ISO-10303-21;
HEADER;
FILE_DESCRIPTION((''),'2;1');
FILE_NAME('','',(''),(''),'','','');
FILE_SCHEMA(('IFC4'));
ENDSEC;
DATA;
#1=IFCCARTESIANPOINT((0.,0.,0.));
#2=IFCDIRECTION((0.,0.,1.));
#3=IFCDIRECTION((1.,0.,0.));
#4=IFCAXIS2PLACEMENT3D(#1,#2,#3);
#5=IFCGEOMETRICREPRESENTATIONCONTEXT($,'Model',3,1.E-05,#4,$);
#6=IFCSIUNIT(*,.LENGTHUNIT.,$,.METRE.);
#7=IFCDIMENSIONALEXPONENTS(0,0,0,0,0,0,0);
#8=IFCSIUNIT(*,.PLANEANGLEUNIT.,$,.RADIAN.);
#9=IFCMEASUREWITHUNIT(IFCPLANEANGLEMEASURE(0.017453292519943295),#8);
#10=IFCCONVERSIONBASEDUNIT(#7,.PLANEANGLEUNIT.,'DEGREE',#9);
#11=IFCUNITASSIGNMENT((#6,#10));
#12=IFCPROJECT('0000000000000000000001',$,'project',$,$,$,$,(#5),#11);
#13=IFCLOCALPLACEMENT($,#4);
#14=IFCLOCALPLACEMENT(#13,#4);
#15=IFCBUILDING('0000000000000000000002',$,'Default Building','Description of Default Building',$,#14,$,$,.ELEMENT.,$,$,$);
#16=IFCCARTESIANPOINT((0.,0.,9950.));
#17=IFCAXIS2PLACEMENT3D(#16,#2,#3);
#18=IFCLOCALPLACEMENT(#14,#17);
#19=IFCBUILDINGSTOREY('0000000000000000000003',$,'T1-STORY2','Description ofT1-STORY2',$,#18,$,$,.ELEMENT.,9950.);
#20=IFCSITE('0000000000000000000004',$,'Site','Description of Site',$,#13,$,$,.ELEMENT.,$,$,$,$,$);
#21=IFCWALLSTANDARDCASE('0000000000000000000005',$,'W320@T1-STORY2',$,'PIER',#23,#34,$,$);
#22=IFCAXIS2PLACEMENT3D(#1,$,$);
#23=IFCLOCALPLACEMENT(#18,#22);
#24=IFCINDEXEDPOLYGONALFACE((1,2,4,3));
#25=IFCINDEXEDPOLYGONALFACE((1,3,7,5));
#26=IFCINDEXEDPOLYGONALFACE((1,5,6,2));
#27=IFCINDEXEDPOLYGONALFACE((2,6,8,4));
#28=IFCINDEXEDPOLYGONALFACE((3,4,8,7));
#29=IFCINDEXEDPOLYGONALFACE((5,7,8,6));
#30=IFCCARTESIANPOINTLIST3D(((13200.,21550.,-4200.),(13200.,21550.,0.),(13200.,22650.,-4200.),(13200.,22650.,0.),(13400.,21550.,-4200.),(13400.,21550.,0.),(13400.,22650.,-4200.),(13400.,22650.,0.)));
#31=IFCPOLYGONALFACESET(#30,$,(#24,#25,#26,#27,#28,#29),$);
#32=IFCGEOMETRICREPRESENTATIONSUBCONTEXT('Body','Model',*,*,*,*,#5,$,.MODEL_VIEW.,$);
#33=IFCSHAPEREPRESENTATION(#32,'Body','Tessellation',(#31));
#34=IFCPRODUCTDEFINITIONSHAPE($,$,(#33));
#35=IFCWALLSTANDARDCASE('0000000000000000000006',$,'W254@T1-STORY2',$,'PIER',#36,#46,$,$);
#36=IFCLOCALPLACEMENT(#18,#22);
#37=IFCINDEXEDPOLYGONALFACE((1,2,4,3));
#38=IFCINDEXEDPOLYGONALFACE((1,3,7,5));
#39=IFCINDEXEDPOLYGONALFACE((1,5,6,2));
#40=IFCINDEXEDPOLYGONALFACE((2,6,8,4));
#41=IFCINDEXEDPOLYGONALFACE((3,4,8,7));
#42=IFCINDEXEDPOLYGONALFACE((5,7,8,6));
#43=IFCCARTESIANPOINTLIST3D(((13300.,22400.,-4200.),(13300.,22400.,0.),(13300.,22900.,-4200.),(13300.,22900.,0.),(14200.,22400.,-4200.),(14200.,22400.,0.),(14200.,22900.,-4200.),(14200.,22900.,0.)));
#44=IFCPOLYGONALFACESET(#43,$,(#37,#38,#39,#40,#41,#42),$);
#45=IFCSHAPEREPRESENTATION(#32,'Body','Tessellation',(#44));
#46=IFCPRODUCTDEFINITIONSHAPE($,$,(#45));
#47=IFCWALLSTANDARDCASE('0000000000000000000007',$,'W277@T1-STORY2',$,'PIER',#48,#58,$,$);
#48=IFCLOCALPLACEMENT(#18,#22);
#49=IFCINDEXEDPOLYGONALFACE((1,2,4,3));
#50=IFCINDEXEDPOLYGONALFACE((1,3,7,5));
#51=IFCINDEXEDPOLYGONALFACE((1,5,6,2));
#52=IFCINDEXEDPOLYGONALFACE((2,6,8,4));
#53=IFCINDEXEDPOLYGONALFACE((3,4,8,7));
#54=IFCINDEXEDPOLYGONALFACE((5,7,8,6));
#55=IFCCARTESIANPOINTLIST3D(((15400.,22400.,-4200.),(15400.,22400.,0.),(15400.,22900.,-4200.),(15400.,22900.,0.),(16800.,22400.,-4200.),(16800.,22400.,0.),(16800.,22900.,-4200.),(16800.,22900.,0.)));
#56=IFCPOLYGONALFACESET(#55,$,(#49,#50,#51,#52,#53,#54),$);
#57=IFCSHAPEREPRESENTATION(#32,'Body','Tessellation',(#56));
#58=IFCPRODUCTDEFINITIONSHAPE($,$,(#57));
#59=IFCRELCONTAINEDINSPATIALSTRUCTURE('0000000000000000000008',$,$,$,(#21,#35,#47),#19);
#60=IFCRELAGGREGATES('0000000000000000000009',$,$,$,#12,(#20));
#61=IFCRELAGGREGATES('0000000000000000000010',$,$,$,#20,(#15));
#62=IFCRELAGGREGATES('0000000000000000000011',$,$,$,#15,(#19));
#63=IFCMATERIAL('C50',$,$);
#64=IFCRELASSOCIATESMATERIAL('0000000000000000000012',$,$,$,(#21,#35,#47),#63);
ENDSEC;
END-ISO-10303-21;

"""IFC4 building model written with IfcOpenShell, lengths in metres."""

from ifc_helpers import new_model, entity, si_unit, converted_unit, frame, origin_with_axes, place, context, subcontext, project, spatial, indexed_curve, outline, extrude, material, element, save


model = new_model("IFC4")

# Units and contexts
model_context = context("Model", 3, precision=1e-05, world=origin_with_axes())
body_context = subcontext(model_context, "Body", "Model", "MODEL_VIEW")
ifc_project = project(units=[si_unit("LENGTHUNIT", "METRE"), converted_unit("PLANEANGLEUNIT", "DEGREE", entity("IfcPlaneAngleMeasure", 0.017453292519943295), si_unit("PLANEANGLEUNIT", "RADIAN"), dimensions=[0, 0, 0, 0, 0, 0, 0])], contexts=[model_context])

# Site, building, storey
site_placement = place(None, origin_with_axes())
site = spatial("IfcSite", under=ifc_project, at=site_placement, Name="Site", Description="Description of Site", CompositionType="ELEMENT")
building_placement = place(site_placement, origin_with_axes())
building = spatial("IfcBuilding", under=site, at=building_placement, Name="Default Building", Description="Description of Default Building", CompositionType="ELEMENT")
storey_placement = place(building_placement, frame((0.0, 0.0, 9950.0), z_axis=(0.0, 0.0, 1.0), x_axis=(1.0, 0.0, 0.0)))
storey = spatial("IfcBuildingStorey", under=building, at=storey_placement, Name="T1-STORY2", Description="Description ofT1-STORY2", CompositionType="ELEMENT", Elevation=9950.0)

# Shared definitions
ifc_material_1 = material(Name="C50")

# Walls
wall_1_placement = place(storey_placement, frame((13300.0, 21550.0, -4200.0), z_axis=(0.0, 0.0, 1.0), x_axis=(0.0, 1.0, 0.0)))
element("IfcWallStandardCase", 1, at=wall_1_placement, inside=storey, material=ifc_material_1, Name="W320@T1-STORY2", ObjectType="PIER", context=body_context, shape_type="SweptSolid", body=[
    extrude(outline(indexed_curve([(0.0, -100.0), (0.0, 100.0), (1100.0, 100.0), (1100.0, -100.0), (0.0, -100.0)], self_intersect=False)), origin_with_axes(), (0.0, 0.0, 1.0), 4200.0),
])
wall_2_placement = place(storey_placement, frame((13300.0, 22650.0, -4200.0), z_axis=(0.0, 0.0, 1.0), x_axis=(1.0, 0.0, 0.0)))
element("IfcWallStandardCase", 2, at=wall_2_placement, inside=storey, material=ifc_material_1, Name="W254@T1-STORY2", ObjectType="PIER", context=body_context, shape_type="SweptSolid", body=[
    extrude(outline(indexed_curve([(0.0, -250.0), (0.0, 250.0), (900.0, 250.0), (900.0, -250.0), (0.0, -250.0)], self_intersect=False)), origin_with_axes(), (0.0, 0.0, 1.0), 4200.0),
])
wall_3_placement = place(storey_placement, frame((15400.0, 22650.0, -4200.0), z_axis=(0.0, 0.0, 1.0), x_axis=(1.0, 0.0, 0.0)))
element("IfcWallStandardCase", 3, at=wall_3_placement, inside=storey, material=ifc_material_1, Name="W277@T1-STORY2", ObjectType="PIER", context=body_context, shape_type="SweptSolid", body=[
    extrude(outline(indexed_curve([(0.0, -250.0), (0.0, 250.0), (1400.0, 250.0), (1400.0, -250.0), (0.0, -250.0)], self_intersect=False)), origin_with_axes(), (0.0, 0.0, 1.0), 4200.0),
])

save(model, "model.ifc")
